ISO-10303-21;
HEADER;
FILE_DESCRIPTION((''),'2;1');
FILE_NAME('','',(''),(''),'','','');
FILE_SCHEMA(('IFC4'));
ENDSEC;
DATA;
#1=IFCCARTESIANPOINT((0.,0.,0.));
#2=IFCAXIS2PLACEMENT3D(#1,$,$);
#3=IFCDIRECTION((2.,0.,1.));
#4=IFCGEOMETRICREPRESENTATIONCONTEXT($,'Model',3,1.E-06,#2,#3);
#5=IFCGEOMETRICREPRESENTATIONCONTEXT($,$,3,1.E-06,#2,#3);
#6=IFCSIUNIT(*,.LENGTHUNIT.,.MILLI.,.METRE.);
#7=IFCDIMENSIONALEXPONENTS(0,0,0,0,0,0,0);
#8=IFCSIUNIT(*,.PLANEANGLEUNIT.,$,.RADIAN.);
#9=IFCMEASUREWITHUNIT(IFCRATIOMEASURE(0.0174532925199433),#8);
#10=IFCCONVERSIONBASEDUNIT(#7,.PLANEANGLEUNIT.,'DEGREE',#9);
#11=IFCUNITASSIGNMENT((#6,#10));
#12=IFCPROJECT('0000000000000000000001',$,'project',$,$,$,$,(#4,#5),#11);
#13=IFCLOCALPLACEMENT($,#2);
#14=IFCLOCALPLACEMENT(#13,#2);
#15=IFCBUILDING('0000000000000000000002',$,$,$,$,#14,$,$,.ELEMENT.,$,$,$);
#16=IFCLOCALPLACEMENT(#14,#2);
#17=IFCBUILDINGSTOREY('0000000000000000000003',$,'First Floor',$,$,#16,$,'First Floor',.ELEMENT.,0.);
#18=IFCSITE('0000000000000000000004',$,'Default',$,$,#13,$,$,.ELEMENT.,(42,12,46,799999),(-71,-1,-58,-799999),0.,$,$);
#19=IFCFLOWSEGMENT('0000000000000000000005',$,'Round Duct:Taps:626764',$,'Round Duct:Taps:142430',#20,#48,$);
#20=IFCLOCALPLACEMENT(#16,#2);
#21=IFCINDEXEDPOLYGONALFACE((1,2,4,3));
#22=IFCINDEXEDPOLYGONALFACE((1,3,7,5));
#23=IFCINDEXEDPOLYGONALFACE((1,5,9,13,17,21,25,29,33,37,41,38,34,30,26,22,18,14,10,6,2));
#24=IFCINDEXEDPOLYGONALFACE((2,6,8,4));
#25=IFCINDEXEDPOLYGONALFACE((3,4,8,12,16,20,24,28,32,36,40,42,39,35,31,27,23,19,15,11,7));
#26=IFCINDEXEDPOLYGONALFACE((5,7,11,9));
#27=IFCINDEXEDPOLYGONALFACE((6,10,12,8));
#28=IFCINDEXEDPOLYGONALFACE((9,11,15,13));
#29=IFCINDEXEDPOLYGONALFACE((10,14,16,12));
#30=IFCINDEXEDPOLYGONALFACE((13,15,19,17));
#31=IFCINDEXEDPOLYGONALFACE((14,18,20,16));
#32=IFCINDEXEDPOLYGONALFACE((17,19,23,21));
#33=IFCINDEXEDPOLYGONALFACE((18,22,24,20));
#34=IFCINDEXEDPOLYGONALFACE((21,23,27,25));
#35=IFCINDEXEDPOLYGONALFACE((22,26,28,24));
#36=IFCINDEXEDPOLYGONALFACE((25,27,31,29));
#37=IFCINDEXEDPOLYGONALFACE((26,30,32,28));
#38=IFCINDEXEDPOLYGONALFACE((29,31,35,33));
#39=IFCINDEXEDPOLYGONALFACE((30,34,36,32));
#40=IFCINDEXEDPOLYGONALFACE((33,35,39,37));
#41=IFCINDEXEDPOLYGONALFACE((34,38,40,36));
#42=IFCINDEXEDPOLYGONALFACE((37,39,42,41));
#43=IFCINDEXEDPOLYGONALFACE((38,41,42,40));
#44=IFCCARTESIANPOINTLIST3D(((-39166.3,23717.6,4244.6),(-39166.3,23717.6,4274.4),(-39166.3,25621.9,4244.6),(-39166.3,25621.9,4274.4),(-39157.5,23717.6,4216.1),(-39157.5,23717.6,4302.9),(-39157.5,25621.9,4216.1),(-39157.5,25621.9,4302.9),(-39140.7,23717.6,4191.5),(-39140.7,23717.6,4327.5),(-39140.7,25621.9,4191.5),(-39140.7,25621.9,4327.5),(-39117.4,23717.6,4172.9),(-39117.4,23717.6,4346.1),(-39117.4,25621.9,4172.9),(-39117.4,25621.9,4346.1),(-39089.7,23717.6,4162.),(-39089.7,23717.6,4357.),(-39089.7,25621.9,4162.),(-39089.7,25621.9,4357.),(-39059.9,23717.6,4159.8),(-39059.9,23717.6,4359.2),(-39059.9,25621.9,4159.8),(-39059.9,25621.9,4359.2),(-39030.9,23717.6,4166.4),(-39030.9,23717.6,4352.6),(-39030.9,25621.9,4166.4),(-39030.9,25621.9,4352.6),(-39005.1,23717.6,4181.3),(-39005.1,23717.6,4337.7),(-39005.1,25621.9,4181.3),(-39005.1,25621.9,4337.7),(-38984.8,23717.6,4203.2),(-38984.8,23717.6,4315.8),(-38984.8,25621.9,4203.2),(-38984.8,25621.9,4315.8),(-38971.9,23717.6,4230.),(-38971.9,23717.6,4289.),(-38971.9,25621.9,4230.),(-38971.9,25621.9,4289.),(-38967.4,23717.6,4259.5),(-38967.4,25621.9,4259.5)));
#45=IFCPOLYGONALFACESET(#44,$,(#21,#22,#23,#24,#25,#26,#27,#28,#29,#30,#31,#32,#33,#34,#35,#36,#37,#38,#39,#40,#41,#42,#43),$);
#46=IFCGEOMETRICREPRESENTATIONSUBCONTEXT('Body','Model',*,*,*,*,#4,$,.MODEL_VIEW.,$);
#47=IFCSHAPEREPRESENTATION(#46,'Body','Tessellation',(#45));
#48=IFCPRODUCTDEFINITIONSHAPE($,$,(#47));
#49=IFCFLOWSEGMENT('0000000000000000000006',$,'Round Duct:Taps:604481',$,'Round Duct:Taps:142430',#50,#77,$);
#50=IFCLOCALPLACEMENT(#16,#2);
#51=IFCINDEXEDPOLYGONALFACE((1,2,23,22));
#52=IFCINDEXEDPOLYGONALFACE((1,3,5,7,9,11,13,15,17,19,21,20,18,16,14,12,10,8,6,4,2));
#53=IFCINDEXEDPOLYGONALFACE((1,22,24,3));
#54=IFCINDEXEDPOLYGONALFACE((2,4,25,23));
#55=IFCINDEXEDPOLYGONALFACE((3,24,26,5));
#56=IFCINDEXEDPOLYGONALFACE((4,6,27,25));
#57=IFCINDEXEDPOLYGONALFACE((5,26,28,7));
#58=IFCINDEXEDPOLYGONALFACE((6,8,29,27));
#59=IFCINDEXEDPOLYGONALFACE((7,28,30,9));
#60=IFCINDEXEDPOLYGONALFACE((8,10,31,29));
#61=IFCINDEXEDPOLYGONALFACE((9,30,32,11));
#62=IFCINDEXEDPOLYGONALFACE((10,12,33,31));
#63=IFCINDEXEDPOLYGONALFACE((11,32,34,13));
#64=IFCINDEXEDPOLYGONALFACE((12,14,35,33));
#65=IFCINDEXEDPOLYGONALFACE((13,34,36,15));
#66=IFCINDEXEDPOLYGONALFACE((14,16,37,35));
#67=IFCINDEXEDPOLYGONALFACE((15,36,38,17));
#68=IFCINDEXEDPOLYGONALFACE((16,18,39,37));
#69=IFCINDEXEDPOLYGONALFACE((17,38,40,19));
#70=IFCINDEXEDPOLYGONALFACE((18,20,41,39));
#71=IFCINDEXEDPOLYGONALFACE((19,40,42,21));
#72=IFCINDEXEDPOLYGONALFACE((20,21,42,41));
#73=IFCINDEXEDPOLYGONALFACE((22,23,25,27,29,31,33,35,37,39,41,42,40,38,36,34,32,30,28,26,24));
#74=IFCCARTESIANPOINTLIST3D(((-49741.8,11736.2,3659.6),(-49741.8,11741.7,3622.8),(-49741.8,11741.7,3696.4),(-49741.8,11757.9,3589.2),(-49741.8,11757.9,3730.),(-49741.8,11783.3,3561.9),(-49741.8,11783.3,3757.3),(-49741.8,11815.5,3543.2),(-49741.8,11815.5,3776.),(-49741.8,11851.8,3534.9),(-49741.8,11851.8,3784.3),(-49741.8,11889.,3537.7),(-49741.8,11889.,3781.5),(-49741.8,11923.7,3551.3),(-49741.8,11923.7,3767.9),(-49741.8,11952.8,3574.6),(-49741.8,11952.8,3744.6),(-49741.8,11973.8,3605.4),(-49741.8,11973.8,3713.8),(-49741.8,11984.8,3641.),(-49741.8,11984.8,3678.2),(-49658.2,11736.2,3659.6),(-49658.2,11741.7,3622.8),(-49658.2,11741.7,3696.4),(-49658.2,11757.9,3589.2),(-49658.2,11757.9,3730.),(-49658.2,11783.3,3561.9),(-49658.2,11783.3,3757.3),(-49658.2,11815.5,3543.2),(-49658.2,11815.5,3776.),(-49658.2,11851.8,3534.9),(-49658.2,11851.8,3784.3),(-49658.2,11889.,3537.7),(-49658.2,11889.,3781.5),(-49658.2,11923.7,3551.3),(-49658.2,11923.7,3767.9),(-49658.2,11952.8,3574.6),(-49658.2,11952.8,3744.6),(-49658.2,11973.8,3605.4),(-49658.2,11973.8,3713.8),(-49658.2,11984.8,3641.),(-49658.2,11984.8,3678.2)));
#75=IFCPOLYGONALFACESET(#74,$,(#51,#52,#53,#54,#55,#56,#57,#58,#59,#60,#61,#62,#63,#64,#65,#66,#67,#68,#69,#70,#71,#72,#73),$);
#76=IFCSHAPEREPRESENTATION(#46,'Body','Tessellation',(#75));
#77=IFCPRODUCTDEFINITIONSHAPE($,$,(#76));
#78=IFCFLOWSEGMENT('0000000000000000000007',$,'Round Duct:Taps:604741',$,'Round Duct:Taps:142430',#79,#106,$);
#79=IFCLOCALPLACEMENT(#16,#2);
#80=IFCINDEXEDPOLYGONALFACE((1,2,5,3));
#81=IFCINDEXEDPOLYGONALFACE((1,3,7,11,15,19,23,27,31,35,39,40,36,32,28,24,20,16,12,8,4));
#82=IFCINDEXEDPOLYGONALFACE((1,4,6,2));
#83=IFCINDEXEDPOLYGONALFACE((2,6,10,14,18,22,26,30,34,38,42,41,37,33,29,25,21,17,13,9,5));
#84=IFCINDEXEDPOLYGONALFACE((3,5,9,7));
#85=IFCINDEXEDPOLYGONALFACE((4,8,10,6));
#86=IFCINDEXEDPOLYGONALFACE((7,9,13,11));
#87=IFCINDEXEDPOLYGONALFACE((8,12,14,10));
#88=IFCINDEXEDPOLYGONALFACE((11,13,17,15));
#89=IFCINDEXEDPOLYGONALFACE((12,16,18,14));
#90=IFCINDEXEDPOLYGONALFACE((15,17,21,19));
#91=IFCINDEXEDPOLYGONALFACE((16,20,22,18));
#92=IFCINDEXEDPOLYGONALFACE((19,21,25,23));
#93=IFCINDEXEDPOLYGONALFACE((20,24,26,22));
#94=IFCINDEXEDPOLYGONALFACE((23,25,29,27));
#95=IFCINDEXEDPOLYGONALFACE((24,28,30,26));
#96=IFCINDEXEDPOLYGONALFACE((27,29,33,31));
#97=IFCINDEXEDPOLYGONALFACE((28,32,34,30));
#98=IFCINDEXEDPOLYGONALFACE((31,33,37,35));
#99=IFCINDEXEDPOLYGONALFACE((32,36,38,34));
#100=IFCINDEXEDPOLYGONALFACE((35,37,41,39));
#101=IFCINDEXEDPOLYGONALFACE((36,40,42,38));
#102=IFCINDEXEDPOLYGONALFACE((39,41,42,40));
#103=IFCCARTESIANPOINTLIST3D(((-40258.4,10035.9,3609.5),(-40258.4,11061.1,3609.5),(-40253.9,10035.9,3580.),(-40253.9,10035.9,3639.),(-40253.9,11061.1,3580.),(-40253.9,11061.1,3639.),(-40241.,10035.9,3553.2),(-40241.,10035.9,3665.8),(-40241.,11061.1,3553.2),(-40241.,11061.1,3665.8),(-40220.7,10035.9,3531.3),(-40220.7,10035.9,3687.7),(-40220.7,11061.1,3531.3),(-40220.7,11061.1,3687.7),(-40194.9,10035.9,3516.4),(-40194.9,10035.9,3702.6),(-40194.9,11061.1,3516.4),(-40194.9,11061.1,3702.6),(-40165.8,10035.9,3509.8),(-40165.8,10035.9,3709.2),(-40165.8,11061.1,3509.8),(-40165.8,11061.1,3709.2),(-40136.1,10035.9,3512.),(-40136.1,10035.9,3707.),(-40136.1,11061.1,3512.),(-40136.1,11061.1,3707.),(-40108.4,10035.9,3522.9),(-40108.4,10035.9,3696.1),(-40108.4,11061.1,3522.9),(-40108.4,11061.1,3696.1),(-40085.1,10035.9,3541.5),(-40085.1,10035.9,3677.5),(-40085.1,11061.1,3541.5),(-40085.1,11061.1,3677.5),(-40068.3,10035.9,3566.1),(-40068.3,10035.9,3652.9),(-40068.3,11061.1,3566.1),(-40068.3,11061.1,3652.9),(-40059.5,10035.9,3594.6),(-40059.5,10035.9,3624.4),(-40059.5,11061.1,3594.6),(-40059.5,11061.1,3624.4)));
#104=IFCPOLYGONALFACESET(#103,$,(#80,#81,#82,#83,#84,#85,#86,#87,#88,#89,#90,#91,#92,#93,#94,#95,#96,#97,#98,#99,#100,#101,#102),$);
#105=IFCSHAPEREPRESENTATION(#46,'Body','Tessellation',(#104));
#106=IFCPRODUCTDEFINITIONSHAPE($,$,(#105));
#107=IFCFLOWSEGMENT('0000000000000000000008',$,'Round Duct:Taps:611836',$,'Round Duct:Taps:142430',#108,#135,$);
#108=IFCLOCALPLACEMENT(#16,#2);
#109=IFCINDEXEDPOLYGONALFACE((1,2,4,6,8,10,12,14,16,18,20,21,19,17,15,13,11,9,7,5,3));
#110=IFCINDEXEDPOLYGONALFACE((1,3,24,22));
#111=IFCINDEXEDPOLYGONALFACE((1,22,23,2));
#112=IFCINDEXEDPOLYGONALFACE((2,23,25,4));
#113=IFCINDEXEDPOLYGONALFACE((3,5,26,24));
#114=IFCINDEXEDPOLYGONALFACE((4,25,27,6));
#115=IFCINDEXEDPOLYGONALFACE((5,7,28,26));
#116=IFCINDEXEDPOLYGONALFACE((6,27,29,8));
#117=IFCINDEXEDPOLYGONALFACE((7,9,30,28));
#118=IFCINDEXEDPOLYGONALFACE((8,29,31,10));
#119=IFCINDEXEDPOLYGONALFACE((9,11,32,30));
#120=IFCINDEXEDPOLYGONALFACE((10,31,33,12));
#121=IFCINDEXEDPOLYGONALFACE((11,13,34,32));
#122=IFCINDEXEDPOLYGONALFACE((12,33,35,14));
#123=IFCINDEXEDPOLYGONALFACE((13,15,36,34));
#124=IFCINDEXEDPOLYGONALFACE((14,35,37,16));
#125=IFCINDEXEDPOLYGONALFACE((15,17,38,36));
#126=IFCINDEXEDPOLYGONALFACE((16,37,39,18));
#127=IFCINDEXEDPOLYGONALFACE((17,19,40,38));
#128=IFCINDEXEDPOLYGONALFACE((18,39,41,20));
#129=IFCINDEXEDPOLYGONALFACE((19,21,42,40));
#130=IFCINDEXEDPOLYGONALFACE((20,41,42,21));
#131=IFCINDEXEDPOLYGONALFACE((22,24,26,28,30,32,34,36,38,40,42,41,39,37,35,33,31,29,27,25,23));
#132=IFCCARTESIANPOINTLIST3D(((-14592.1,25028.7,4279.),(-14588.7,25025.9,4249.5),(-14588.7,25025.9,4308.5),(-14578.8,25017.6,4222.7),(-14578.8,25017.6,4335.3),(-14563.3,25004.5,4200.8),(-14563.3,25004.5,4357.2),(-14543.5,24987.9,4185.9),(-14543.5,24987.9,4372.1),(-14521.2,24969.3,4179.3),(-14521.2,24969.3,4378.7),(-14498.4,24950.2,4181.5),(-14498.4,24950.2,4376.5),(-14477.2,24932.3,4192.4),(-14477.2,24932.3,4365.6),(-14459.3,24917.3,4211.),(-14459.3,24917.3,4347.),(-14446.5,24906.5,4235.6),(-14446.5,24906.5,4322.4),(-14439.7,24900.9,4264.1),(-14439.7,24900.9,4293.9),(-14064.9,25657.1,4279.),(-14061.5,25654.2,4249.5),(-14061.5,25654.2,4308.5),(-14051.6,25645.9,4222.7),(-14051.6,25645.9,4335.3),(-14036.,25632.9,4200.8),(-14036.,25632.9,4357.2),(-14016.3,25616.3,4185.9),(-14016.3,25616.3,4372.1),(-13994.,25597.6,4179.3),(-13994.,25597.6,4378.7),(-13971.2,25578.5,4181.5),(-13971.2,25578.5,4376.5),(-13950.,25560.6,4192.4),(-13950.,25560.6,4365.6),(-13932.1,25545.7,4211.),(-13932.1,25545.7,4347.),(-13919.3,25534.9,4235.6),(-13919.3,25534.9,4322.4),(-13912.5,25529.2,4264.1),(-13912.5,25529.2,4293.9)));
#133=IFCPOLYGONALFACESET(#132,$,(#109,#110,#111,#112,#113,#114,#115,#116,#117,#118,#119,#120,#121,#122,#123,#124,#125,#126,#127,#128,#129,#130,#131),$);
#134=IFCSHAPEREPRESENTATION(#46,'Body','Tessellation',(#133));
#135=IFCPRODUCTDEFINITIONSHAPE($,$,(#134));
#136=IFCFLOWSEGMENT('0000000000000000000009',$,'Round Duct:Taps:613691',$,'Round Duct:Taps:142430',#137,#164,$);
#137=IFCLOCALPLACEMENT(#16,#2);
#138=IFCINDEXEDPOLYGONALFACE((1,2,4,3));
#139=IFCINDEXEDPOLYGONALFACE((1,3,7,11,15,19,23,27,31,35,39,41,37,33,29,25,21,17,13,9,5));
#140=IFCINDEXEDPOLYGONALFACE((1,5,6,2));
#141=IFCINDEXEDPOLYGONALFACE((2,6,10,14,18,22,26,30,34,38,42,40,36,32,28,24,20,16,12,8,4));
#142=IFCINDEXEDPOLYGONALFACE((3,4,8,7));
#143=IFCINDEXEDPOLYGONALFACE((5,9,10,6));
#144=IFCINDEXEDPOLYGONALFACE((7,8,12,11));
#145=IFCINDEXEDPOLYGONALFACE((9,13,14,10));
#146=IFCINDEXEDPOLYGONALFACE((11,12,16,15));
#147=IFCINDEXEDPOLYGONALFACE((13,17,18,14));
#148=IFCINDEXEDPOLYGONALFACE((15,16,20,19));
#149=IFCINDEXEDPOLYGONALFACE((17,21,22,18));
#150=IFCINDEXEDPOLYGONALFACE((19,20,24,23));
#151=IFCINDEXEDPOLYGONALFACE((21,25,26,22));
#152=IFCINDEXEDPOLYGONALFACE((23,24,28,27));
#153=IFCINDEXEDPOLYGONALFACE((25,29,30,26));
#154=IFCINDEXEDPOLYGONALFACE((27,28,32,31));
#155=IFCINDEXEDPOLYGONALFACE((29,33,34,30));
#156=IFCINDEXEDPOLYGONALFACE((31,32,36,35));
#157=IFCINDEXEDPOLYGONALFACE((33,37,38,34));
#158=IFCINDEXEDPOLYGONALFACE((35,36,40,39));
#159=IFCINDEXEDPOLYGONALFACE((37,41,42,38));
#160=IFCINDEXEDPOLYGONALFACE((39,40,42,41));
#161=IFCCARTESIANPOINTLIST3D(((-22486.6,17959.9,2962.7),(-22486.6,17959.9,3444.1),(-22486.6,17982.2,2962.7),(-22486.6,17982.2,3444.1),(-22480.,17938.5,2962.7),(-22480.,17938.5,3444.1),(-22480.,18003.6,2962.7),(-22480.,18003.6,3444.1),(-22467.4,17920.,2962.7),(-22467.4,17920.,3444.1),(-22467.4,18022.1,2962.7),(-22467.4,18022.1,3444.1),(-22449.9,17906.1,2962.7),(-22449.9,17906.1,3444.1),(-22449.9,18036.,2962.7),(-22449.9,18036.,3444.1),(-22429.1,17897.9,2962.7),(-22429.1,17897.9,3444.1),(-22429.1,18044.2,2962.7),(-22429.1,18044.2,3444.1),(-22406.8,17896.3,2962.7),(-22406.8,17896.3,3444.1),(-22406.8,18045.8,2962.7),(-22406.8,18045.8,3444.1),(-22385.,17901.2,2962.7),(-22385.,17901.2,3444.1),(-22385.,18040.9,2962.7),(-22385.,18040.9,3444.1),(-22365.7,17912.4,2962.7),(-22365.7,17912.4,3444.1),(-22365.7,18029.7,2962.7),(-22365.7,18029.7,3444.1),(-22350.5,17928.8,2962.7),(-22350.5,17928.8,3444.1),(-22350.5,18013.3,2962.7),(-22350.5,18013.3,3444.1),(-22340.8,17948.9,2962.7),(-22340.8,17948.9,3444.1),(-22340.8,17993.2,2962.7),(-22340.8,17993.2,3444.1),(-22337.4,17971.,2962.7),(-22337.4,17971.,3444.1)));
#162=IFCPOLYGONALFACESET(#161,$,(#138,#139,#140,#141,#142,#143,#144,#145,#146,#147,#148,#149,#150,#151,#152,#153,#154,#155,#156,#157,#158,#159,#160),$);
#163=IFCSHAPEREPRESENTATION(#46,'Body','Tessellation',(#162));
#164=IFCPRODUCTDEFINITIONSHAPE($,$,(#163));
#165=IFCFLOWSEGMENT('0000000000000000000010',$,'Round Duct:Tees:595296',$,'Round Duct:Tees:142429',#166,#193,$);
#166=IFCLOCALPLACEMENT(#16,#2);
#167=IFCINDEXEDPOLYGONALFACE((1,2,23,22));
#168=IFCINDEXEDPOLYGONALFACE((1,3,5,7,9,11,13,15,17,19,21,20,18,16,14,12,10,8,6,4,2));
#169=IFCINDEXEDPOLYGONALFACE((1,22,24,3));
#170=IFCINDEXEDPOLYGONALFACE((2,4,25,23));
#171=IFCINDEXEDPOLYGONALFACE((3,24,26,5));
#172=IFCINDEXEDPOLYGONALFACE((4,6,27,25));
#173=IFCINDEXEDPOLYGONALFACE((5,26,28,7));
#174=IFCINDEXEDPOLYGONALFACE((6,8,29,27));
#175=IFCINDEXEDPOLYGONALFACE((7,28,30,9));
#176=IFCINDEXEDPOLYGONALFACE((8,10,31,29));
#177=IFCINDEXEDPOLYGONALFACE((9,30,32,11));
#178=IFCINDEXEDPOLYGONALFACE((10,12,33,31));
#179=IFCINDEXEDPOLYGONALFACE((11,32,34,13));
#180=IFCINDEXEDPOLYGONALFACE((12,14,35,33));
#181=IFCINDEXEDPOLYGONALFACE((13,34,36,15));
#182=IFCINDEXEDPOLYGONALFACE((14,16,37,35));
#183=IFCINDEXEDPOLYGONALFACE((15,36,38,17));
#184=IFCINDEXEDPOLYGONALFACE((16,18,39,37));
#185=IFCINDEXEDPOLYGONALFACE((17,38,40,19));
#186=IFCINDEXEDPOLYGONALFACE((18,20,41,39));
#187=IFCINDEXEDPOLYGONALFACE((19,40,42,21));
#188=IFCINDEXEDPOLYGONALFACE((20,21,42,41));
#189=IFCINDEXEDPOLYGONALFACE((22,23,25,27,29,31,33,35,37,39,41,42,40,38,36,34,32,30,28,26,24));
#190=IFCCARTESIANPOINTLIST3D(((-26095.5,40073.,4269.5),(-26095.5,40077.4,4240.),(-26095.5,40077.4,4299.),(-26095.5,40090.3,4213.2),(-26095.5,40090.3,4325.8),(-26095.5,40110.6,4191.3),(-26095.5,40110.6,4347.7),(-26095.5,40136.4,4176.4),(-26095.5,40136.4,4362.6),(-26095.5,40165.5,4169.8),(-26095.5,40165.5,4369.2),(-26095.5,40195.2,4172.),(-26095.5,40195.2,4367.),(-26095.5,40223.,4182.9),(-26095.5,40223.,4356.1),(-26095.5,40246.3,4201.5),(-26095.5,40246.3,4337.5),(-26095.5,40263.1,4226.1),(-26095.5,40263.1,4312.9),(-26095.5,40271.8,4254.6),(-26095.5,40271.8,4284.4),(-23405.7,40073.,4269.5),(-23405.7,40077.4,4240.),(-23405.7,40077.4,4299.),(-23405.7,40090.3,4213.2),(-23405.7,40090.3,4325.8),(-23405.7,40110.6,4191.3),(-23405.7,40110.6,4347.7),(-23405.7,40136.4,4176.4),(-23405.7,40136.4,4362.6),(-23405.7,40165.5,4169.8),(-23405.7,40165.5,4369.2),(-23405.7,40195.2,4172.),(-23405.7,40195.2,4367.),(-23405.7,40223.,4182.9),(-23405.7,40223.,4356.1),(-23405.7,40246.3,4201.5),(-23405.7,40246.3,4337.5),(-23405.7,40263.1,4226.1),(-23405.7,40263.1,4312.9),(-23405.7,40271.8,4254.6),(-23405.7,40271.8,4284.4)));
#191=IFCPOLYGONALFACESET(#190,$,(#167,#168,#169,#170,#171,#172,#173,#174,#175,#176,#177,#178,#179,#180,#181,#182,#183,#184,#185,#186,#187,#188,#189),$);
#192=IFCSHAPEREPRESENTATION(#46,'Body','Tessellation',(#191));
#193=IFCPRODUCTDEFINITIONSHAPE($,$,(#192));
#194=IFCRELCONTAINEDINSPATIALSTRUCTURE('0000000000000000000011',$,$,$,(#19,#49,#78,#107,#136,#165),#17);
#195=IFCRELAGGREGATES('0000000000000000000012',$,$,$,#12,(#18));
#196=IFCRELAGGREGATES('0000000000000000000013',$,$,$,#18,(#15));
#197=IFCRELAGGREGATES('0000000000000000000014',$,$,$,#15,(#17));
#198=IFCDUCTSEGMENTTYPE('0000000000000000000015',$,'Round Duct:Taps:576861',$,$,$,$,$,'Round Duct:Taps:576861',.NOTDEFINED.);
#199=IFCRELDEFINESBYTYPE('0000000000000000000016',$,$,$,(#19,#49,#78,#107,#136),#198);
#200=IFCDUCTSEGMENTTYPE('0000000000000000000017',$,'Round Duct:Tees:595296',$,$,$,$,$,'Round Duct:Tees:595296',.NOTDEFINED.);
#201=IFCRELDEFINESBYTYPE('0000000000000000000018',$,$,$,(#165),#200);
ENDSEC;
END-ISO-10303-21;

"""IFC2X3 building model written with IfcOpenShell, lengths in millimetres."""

from ifc_helpers import new_model, entity, si_unit, converted_unit, direction, frame, frame_2d, origin, origin_2d_with_axis, place, context, subcontext, project, spatial, circle, extrude, type_object, element, save


model = new_model("IFC2X3")

# Units and contexts
model_context = context("Model", 3, precision=1e-06, world=origin(), true_north=direction((2.0, 0.0, 1.0)))
context_of_model = context(None, 3, precision=1e-06, world=origin(), true_north=direction((2.0, 0.0, 1.0)))
body_context = subcontext(model_context, "Body", "Model", "MODEL_VIEW")
ifc_project = project(units=[si_unit("LENGTHUNIT", "METRE", prefix="MILLI"), converted_unit("PLANEANGLEUNIT", "DEGREE", entity("IfcRatioMeasure", 0.0174532925199433), si_unit("PLANEANGLEUNIT", "RADIAN"), dimensions=[0, 0, 0, 0, 0, 0, 0])], contexts=[model_context, context_of_model])

# Site, building, storey
site_placement = place(None, origin())
site = spatial("IfcSite", under=ifc_project, at=site_placement, Name="Default", CompositionType="ELEMENT", RefLatitude=(42, 12, 46, 799999), RefLongitude=(-71, -1, -58, -799999), RefElevation=0.0)
building_placement = place(site_placement, origin())
building = spatial("IfcBuilding", under=site, at=building_placement, CompositionType="ELEMENT")
storey_placement = place(building_placement, origin())
storey = spatial("IfcBuildingStorey", under=building, at=storey_placement, Name="First Floor", LongName="First Floor", CompositionType="ELEMENT", Elevation=0.0)

# Flow segments
duct_segment_type_1 = type_object("IfcDuctSegmentType", Name="Round Duct:Taps:576861", ElementType="Round Duct:Taps:576861", PredefinedType="NOTDEFINED")
flow_segment_1_placement = place(storey_placement, origin())
element("IfcFlowSegment", 1, at=flow_segment_1_placement, inside=storey, type_object=duct_segment_type_1, Name="Round Duct:Taps:626764", ObjectType="Round Duct:Taps:142430", context=body_context, shape_type="SweptSolid", body=[
    extrude(circle(Radius=100.0, at=origin_2d_with_axis()), frame((-39067.4, 23717.6, 4259.5), z_axis=(0.0, 1.0, 0.0), x_axis=(1.0, 0.0, 0.0)), (0.0, 0.0, 1.0), 1904.2),
])
flow_segment_2_placement = place(storey_placement, origin())
element("IfcFlowSegment", 2, at=flow_segment_2_placement, inside=storey, type_object=duct_segment_type_1, Name="Round Duct:Taps:604481", ObjectType="Round Duct:Taps:142430", context=body_context, shape_type="SweptSolid", body=[
    extrude(circle(Radius=125.0, at=origin_2d_with_axis()), frame((-49741.8, 11861.2, 3659.6), z_axis=(1.0, 0.0, 0.0), x_axis=(0.0, -1.0, 0.0)), (0.0, 0.0, 1.0), 83.6),
])
flow_segment_3_placement = place(storey_placement, origin())
element("IfcFlowSegment", 3, at=flow_segment_3_placement, inside=storey, type_object=duct_segment_type_1, Name="Round Duct:Taps:604741", ObjectType="Round Duct:Taps:142430", context=body_context, shape_type="SweptSolid", body=[
    extrude(circle(Radius=100.0, at=frame_2d((0.0, 0.0), x_axis=(1.0, 0.0))), frame((-40158.4, 10035.9, 3609.5), z_axis=(0.0, 1.0, 0.0), x_axis=(-1.0, 0.0, 0.0)), (0.0, 0.0, 1.0), 1025.2),
])
flow_segment_4_placement = place(storey_placement, origin())
element("IfcFlowSegment", 4, at=flow_segment_4_placement, inside=storey, type_object=duct_segment_type_1, Name="Round Duct:Taps:611836", ObjectType="Round Duct:Taps:142430", context=body_context, shape_type="SweptSolid", body=[
    extrude(circle(Radius=100.0, at=frame_2d((0.0, 0.0), x_axis=(1.0, 0.0))), frame((-14515.5, 24964.5, 4279.0), z_axis=(0.642788, 0.766044, 0.0), x_axis=(-0.766044, 0.642788, 0.0)), (0.0, 0.0, 1.0), 820.2),
])
flow_segment_5_placement = place(storey_placement, origin())
element("IfcFlowSegment", 5, at=flow_segment_5_placement, inside=storey, type_object=duct_segment_type_1, Name="Round Duct:Taps:613691", ObjectType="Round Duct:Taps:142430", context=body_context, shape_type="SweptSolid", body=[
    extrude(circle(Radius=75.0, at=origin_2d_with_axis()), frame((-22412.4, 17971.0, 2962.7)), (0.0, 0.0, 1.0), 481.4),
])
duct_segment_type_2 = type_object("IfcDuctSegmentType", Name="Round Duct:Tees:595296", ElementType="Round Duct:Tees:595296", PredefinedType="NOTDEFINED")
flow_segment_6_placement = place(storey_placement, origin())
element("IfcFlowSegment", 6, at=flow_segment_6_placement, inside=storey, type_object=duct_segment_type_2, Name="Round Duct:Tees:595296", ObjectType="Round Duct:Tees:142429", context=body_context, shape_type="SweptSolid", body=[
    extrude(circle(Radius=100.0, at=origin_2d_with_axis()), frame((-26095.5, 40173.0, 4269.5), z_axis=(1.0, 0.0, 0.0), x_axis=(0.0, -1.0, 0.0)), (0.0, 0.0, 1.0), 2689.7),
])

save(model, "model.ifc")
